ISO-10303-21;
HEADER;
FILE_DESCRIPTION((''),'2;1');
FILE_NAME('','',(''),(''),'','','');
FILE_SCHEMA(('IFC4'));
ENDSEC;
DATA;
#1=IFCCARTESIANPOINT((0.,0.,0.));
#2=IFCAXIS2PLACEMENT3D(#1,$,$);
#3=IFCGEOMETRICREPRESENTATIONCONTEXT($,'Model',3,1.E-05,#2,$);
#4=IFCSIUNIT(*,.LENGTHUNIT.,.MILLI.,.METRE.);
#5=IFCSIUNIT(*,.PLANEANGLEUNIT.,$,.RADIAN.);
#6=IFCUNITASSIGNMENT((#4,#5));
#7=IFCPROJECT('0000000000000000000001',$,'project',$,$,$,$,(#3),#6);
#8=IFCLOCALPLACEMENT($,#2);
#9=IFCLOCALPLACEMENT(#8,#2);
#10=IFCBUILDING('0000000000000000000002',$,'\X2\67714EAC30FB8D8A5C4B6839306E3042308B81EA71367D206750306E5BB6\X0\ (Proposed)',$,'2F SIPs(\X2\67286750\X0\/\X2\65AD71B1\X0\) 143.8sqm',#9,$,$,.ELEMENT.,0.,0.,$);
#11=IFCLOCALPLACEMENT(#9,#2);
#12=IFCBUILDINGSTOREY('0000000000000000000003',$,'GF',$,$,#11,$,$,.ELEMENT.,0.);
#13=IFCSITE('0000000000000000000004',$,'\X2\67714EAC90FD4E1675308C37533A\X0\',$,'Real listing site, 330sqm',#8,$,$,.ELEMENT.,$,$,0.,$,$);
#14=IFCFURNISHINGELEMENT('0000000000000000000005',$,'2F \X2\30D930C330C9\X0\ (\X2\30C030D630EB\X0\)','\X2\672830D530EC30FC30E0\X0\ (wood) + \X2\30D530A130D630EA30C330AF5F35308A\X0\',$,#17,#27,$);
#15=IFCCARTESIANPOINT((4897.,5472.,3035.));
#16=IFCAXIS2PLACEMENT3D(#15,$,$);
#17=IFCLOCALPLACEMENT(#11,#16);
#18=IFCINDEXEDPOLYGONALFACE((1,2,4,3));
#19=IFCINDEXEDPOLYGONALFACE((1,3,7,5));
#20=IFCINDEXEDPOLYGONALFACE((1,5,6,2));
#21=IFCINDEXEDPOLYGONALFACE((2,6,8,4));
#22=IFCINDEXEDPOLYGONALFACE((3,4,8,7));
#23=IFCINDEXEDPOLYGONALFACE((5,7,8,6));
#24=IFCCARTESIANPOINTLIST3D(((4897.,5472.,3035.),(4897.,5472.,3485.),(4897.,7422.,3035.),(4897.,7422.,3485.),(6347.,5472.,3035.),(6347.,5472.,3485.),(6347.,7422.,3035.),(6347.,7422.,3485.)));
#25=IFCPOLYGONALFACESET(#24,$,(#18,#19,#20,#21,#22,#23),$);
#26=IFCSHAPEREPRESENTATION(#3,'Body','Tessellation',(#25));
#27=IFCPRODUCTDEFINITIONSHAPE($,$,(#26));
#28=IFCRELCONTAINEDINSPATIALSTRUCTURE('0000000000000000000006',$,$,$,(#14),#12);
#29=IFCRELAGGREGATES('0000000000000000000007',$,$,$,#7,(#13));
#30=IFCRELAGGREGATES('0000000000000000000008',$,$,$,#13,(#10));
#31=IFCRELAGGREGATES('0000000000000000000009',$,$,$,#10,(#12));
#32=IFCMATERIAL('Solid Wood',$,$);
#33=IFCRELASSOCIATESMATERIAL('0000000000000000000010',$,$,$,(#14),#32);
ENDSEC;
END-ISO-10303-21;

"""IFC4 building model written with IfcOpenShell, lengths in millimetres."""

from ifc_helpers import new_model, si_unit, frame, frame_2d, origin, place, context, project, spatial, rectangle, extrude, material, element, save


model = new_model("IFC4")

# Units and contexts
model_context = context("Model", 3, precision=1e-05, world=origin())
ifc_project = project(units=[si_unit("LENGTHUNIT", "METRE", prefix="MILLI"), si_unit("PLANEANGLEUNIT", "RADIAN")], contexts=[model_context])

# Site, building, storey
site_placement = place(None, origin())
site = spatial("IfcSite", under=ifc_project, at=site_placement, Name="東京都世田谷区", ObjectType="Real listing site, 330sqm", CompositionType="ELEMENT", RefElevation=0.0)
building_placement = place(site_placement, origin())
building = spatial("IfcBuilding", under=site, at=building_placement, Name="東京・越屋根のある自然素材の家 (Proposed)", ObjectType="2F SIPs(木材/断熱) 143.8sqm", CompositionType="ELEMENT", ElevationOfRefHeight=0.0, ElevationOfTerrain=0.0)
storey_placement = place(building_placement, origin())
storey = spatial("IfcBuildingStorey", under=building, at=storey_placement, Name="GF", CompositionType="ELEMENT", Elevation=0.0)

# Shared definitions
ifc_material_1 = material(Name="Solid Wood")

# Furnishing element
furnishing_1_placement = place(storey_placement, frame((4897.0, 5472.0, 3035.0)))
element("IfcFurnishingElement", 1, at=furnishing_1_placement, inside=storey, material=ifc_material_1, Name="2F ベッド (ダブル)", Description="木フレーム (wood) + ファブリック張り", context=model_context, shape_type="SweptSolid", body=[
    extrude(rectangle(XDim=1450.0, YDim=1950.0, at=frame_2d((725.0, 975.0))), frame((4897.0, 5472.0, 3035.0)), (0.0, 0.0, 1.0), 450.0),
])

save(model, "model.ifc")
